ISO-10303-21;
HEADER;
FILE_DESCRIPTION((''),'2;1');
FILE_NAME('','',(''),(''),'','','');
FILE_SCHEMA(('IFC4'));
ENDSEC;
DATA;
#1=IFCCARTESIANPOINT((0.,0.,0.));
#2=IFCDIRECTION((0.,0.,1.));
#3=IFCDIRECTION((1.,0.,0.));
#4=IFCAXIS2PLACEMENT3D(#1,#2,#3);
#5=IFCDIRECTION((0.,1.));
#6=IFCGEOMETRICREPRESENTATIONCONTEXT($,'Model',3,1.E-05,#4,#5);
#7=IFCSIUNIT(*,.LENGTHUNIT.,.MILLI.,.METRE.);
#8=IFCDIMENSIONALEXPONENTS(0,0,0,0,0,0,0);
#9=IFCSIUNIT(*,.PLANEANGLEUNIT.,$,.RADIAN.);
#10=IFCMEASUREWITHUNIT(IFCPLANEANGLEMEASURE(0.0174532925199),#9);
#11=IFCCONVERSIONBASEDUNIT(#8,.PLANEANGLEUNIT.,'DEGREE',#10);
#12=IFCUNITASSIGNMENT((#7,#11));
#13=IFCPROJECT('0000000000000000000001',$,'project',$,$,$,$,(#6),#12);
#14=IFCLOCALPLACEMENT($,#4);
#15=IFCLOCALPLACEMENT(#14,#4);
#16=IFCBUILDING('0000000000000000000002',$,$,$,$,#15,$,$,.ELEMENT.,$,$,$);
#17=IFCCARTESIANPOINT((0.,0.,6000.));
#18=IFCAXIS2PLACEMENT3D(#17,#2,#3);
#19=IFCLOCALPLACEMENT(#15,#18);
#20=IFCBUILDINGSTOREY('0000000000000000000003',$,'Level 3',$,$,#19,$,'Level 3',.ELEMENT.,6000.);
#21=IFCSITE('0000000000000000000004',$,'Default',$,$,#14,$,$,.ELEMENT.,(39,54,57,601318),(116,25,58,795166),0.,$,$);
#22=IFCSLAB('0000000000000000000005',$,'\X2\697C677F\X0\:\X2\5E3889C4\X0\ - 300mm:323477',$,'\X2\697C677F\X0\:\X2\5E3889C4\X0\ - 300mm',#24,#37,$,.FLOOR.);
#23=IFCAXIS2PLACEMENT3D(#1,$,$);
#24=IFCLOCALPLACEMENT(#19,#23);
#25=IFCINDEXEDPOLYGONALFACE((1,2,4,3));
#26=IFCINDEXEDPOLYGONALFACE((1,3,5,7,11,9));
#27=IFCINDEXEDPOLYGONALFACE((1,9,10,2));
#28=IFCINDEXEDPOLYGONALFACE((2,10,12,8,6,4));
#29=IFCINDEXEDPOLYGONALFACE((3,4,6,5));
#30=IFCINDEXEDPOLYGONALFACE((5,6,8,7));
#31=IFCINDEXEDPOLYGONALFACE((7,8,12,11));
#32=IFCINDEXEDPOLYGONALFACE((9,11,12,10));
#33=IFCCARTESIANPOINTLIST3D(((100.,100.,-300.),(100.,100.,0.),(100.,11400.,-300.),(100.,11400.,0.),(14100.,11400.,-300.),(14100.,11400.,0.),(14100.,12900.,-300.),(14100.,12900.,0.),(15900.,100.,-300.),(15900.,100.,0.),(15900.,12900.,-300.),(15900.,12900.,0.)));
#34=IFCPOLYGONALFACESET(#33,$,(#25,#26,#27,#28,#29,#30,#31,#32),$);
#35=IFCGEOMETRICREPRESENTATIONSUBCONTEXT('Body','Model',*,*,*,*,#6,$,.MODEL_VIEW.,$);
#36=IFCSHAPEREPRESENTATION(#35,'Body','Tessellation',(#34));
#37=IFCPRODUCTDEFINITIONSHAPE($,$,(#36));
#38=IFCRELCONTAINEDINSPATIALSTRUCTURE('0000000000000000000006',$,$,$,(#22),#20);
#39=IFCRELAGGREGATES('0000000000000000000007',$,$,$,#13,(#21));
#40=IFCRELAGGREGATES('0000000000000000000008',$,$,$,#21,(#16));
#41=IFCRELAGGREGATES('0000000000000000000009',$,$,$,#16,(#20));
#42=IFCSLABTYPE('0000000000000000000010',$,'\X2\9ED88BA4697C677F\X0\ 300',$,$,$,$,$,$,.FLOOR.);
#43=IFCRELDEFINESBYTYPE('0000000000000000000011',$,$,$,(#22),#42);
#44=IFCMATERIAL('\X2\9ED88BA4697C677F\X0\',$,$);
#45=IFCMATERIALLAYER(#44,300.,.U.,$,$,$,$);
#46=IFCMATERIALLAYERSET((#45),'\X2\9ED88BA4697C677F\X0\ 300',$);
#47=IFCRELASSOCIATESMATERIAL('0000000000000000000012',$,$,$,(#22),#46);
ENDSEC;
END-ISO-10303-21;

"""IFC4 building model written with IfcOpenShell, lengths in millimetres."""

from ifc_helpers import new_model, entity, si_unit, converted_unit, direction, frame, origin_with_axes, place, context, subcontext, project, spatial, polyline, outline, extrude, material, layer, layer_set, layer_usage, type_object, element, save


model = new_model("IFC4")

# Units and contexts
model_context = context("Model", 3, precision=1e-05, world=origin_with_axes(), true_north=direction((0.0, 1.0)))
body_context = subcontext(model_context, "Body", "Model", "MODEL_VIEW")
ifc_project = project(units=[si_unit("LENGTHUNIT", "METRE", prefix="MILLI"), converted_unit("PLANEANGLEUNIT", "DEGREE", entity("IfcPlaneAngleMeasure", 0.0174532925199), si_unit("PLANEANGLEUNIT", "RADIAN"), dimensions=[0, 0, 0, 0, 0, 0, 0])], contexts=[model_context])

# Site, building, storey
site_placement = place(None, origin_with_axes())
site = spatial("IfcSite", under=ifc_project, at=site_placement, Name="Default", CompositionType="ELEMENT", RefLatitude=(39, 54, 57, 601318), RefLongitude=(116, 25, 58, 795166), RefElevation=0.0)
building_placement = place(site_placement, origin_with_axes())
building = spatial("IfcBuilding", under=site, at=building_placement, CompositionType="ELEMENT")
storey_placement = place(building_placement, frame((0.0, 0.0, 6000.0), z_axis=(0.0, 0.0, 1.0), x_axis=(1.0, 0.0, 0.0)))
storey = spatial("IfcBuildingStorey", under=building, at=storey_placement, Name="Level 3", LongName="Level 3", CompositionType="ELEMENT", Elevation=6000.0)

# Slab
ifc_material = material(Name="默认楼板")
ifc_layer = layer(ifc_material, 300.0, ventilated="UNKNOWN")
ifc_layer_set = layer_set([ifc_layer], Name="默认楼板 300")
ifc_layer_usage = layer_usage(ifc_layer_set, "AXIS3", "NEGATIVE", 300.0)
slab_type = type_object("IfcSlabType", Name="默认楼板 300", PredefinedType="FLOOR")
slab_placement = place(storey_placement, frame((100.0, 100.0, 0.0), z_axis=(0.0, 0.0, 1.0), x_axis=(1.0, 0.0, 0.0)))
element("IfcSlab", 1, at=slab_placement, inside=storey, type_object=slab_type, material=ifc_layer_usage, Name="楼板:常规 - 300mm:323477", ObjectType="楼板:常规 - 300mm", PredefinedType="FLOOR", context=body_context, shape_type="SweptSolid", body=[
    extrude(outline(polyline([(0.0, 0.0), (15800.0, 0.0), (15800.0, 12800.0), (14000.0, 12800.0), (14000.0, 11300.0), (0.0, 11300.0), (0.0, 0.0)])), frame((0.0, 0.0, -300.0), z_axis=(0.0, 0.0, 1.0), x_axis=(1.0, 0.0, 0.0)), (0.0, 0.0, 1.0), 300.0),
])

save(model, "model.ifc")
